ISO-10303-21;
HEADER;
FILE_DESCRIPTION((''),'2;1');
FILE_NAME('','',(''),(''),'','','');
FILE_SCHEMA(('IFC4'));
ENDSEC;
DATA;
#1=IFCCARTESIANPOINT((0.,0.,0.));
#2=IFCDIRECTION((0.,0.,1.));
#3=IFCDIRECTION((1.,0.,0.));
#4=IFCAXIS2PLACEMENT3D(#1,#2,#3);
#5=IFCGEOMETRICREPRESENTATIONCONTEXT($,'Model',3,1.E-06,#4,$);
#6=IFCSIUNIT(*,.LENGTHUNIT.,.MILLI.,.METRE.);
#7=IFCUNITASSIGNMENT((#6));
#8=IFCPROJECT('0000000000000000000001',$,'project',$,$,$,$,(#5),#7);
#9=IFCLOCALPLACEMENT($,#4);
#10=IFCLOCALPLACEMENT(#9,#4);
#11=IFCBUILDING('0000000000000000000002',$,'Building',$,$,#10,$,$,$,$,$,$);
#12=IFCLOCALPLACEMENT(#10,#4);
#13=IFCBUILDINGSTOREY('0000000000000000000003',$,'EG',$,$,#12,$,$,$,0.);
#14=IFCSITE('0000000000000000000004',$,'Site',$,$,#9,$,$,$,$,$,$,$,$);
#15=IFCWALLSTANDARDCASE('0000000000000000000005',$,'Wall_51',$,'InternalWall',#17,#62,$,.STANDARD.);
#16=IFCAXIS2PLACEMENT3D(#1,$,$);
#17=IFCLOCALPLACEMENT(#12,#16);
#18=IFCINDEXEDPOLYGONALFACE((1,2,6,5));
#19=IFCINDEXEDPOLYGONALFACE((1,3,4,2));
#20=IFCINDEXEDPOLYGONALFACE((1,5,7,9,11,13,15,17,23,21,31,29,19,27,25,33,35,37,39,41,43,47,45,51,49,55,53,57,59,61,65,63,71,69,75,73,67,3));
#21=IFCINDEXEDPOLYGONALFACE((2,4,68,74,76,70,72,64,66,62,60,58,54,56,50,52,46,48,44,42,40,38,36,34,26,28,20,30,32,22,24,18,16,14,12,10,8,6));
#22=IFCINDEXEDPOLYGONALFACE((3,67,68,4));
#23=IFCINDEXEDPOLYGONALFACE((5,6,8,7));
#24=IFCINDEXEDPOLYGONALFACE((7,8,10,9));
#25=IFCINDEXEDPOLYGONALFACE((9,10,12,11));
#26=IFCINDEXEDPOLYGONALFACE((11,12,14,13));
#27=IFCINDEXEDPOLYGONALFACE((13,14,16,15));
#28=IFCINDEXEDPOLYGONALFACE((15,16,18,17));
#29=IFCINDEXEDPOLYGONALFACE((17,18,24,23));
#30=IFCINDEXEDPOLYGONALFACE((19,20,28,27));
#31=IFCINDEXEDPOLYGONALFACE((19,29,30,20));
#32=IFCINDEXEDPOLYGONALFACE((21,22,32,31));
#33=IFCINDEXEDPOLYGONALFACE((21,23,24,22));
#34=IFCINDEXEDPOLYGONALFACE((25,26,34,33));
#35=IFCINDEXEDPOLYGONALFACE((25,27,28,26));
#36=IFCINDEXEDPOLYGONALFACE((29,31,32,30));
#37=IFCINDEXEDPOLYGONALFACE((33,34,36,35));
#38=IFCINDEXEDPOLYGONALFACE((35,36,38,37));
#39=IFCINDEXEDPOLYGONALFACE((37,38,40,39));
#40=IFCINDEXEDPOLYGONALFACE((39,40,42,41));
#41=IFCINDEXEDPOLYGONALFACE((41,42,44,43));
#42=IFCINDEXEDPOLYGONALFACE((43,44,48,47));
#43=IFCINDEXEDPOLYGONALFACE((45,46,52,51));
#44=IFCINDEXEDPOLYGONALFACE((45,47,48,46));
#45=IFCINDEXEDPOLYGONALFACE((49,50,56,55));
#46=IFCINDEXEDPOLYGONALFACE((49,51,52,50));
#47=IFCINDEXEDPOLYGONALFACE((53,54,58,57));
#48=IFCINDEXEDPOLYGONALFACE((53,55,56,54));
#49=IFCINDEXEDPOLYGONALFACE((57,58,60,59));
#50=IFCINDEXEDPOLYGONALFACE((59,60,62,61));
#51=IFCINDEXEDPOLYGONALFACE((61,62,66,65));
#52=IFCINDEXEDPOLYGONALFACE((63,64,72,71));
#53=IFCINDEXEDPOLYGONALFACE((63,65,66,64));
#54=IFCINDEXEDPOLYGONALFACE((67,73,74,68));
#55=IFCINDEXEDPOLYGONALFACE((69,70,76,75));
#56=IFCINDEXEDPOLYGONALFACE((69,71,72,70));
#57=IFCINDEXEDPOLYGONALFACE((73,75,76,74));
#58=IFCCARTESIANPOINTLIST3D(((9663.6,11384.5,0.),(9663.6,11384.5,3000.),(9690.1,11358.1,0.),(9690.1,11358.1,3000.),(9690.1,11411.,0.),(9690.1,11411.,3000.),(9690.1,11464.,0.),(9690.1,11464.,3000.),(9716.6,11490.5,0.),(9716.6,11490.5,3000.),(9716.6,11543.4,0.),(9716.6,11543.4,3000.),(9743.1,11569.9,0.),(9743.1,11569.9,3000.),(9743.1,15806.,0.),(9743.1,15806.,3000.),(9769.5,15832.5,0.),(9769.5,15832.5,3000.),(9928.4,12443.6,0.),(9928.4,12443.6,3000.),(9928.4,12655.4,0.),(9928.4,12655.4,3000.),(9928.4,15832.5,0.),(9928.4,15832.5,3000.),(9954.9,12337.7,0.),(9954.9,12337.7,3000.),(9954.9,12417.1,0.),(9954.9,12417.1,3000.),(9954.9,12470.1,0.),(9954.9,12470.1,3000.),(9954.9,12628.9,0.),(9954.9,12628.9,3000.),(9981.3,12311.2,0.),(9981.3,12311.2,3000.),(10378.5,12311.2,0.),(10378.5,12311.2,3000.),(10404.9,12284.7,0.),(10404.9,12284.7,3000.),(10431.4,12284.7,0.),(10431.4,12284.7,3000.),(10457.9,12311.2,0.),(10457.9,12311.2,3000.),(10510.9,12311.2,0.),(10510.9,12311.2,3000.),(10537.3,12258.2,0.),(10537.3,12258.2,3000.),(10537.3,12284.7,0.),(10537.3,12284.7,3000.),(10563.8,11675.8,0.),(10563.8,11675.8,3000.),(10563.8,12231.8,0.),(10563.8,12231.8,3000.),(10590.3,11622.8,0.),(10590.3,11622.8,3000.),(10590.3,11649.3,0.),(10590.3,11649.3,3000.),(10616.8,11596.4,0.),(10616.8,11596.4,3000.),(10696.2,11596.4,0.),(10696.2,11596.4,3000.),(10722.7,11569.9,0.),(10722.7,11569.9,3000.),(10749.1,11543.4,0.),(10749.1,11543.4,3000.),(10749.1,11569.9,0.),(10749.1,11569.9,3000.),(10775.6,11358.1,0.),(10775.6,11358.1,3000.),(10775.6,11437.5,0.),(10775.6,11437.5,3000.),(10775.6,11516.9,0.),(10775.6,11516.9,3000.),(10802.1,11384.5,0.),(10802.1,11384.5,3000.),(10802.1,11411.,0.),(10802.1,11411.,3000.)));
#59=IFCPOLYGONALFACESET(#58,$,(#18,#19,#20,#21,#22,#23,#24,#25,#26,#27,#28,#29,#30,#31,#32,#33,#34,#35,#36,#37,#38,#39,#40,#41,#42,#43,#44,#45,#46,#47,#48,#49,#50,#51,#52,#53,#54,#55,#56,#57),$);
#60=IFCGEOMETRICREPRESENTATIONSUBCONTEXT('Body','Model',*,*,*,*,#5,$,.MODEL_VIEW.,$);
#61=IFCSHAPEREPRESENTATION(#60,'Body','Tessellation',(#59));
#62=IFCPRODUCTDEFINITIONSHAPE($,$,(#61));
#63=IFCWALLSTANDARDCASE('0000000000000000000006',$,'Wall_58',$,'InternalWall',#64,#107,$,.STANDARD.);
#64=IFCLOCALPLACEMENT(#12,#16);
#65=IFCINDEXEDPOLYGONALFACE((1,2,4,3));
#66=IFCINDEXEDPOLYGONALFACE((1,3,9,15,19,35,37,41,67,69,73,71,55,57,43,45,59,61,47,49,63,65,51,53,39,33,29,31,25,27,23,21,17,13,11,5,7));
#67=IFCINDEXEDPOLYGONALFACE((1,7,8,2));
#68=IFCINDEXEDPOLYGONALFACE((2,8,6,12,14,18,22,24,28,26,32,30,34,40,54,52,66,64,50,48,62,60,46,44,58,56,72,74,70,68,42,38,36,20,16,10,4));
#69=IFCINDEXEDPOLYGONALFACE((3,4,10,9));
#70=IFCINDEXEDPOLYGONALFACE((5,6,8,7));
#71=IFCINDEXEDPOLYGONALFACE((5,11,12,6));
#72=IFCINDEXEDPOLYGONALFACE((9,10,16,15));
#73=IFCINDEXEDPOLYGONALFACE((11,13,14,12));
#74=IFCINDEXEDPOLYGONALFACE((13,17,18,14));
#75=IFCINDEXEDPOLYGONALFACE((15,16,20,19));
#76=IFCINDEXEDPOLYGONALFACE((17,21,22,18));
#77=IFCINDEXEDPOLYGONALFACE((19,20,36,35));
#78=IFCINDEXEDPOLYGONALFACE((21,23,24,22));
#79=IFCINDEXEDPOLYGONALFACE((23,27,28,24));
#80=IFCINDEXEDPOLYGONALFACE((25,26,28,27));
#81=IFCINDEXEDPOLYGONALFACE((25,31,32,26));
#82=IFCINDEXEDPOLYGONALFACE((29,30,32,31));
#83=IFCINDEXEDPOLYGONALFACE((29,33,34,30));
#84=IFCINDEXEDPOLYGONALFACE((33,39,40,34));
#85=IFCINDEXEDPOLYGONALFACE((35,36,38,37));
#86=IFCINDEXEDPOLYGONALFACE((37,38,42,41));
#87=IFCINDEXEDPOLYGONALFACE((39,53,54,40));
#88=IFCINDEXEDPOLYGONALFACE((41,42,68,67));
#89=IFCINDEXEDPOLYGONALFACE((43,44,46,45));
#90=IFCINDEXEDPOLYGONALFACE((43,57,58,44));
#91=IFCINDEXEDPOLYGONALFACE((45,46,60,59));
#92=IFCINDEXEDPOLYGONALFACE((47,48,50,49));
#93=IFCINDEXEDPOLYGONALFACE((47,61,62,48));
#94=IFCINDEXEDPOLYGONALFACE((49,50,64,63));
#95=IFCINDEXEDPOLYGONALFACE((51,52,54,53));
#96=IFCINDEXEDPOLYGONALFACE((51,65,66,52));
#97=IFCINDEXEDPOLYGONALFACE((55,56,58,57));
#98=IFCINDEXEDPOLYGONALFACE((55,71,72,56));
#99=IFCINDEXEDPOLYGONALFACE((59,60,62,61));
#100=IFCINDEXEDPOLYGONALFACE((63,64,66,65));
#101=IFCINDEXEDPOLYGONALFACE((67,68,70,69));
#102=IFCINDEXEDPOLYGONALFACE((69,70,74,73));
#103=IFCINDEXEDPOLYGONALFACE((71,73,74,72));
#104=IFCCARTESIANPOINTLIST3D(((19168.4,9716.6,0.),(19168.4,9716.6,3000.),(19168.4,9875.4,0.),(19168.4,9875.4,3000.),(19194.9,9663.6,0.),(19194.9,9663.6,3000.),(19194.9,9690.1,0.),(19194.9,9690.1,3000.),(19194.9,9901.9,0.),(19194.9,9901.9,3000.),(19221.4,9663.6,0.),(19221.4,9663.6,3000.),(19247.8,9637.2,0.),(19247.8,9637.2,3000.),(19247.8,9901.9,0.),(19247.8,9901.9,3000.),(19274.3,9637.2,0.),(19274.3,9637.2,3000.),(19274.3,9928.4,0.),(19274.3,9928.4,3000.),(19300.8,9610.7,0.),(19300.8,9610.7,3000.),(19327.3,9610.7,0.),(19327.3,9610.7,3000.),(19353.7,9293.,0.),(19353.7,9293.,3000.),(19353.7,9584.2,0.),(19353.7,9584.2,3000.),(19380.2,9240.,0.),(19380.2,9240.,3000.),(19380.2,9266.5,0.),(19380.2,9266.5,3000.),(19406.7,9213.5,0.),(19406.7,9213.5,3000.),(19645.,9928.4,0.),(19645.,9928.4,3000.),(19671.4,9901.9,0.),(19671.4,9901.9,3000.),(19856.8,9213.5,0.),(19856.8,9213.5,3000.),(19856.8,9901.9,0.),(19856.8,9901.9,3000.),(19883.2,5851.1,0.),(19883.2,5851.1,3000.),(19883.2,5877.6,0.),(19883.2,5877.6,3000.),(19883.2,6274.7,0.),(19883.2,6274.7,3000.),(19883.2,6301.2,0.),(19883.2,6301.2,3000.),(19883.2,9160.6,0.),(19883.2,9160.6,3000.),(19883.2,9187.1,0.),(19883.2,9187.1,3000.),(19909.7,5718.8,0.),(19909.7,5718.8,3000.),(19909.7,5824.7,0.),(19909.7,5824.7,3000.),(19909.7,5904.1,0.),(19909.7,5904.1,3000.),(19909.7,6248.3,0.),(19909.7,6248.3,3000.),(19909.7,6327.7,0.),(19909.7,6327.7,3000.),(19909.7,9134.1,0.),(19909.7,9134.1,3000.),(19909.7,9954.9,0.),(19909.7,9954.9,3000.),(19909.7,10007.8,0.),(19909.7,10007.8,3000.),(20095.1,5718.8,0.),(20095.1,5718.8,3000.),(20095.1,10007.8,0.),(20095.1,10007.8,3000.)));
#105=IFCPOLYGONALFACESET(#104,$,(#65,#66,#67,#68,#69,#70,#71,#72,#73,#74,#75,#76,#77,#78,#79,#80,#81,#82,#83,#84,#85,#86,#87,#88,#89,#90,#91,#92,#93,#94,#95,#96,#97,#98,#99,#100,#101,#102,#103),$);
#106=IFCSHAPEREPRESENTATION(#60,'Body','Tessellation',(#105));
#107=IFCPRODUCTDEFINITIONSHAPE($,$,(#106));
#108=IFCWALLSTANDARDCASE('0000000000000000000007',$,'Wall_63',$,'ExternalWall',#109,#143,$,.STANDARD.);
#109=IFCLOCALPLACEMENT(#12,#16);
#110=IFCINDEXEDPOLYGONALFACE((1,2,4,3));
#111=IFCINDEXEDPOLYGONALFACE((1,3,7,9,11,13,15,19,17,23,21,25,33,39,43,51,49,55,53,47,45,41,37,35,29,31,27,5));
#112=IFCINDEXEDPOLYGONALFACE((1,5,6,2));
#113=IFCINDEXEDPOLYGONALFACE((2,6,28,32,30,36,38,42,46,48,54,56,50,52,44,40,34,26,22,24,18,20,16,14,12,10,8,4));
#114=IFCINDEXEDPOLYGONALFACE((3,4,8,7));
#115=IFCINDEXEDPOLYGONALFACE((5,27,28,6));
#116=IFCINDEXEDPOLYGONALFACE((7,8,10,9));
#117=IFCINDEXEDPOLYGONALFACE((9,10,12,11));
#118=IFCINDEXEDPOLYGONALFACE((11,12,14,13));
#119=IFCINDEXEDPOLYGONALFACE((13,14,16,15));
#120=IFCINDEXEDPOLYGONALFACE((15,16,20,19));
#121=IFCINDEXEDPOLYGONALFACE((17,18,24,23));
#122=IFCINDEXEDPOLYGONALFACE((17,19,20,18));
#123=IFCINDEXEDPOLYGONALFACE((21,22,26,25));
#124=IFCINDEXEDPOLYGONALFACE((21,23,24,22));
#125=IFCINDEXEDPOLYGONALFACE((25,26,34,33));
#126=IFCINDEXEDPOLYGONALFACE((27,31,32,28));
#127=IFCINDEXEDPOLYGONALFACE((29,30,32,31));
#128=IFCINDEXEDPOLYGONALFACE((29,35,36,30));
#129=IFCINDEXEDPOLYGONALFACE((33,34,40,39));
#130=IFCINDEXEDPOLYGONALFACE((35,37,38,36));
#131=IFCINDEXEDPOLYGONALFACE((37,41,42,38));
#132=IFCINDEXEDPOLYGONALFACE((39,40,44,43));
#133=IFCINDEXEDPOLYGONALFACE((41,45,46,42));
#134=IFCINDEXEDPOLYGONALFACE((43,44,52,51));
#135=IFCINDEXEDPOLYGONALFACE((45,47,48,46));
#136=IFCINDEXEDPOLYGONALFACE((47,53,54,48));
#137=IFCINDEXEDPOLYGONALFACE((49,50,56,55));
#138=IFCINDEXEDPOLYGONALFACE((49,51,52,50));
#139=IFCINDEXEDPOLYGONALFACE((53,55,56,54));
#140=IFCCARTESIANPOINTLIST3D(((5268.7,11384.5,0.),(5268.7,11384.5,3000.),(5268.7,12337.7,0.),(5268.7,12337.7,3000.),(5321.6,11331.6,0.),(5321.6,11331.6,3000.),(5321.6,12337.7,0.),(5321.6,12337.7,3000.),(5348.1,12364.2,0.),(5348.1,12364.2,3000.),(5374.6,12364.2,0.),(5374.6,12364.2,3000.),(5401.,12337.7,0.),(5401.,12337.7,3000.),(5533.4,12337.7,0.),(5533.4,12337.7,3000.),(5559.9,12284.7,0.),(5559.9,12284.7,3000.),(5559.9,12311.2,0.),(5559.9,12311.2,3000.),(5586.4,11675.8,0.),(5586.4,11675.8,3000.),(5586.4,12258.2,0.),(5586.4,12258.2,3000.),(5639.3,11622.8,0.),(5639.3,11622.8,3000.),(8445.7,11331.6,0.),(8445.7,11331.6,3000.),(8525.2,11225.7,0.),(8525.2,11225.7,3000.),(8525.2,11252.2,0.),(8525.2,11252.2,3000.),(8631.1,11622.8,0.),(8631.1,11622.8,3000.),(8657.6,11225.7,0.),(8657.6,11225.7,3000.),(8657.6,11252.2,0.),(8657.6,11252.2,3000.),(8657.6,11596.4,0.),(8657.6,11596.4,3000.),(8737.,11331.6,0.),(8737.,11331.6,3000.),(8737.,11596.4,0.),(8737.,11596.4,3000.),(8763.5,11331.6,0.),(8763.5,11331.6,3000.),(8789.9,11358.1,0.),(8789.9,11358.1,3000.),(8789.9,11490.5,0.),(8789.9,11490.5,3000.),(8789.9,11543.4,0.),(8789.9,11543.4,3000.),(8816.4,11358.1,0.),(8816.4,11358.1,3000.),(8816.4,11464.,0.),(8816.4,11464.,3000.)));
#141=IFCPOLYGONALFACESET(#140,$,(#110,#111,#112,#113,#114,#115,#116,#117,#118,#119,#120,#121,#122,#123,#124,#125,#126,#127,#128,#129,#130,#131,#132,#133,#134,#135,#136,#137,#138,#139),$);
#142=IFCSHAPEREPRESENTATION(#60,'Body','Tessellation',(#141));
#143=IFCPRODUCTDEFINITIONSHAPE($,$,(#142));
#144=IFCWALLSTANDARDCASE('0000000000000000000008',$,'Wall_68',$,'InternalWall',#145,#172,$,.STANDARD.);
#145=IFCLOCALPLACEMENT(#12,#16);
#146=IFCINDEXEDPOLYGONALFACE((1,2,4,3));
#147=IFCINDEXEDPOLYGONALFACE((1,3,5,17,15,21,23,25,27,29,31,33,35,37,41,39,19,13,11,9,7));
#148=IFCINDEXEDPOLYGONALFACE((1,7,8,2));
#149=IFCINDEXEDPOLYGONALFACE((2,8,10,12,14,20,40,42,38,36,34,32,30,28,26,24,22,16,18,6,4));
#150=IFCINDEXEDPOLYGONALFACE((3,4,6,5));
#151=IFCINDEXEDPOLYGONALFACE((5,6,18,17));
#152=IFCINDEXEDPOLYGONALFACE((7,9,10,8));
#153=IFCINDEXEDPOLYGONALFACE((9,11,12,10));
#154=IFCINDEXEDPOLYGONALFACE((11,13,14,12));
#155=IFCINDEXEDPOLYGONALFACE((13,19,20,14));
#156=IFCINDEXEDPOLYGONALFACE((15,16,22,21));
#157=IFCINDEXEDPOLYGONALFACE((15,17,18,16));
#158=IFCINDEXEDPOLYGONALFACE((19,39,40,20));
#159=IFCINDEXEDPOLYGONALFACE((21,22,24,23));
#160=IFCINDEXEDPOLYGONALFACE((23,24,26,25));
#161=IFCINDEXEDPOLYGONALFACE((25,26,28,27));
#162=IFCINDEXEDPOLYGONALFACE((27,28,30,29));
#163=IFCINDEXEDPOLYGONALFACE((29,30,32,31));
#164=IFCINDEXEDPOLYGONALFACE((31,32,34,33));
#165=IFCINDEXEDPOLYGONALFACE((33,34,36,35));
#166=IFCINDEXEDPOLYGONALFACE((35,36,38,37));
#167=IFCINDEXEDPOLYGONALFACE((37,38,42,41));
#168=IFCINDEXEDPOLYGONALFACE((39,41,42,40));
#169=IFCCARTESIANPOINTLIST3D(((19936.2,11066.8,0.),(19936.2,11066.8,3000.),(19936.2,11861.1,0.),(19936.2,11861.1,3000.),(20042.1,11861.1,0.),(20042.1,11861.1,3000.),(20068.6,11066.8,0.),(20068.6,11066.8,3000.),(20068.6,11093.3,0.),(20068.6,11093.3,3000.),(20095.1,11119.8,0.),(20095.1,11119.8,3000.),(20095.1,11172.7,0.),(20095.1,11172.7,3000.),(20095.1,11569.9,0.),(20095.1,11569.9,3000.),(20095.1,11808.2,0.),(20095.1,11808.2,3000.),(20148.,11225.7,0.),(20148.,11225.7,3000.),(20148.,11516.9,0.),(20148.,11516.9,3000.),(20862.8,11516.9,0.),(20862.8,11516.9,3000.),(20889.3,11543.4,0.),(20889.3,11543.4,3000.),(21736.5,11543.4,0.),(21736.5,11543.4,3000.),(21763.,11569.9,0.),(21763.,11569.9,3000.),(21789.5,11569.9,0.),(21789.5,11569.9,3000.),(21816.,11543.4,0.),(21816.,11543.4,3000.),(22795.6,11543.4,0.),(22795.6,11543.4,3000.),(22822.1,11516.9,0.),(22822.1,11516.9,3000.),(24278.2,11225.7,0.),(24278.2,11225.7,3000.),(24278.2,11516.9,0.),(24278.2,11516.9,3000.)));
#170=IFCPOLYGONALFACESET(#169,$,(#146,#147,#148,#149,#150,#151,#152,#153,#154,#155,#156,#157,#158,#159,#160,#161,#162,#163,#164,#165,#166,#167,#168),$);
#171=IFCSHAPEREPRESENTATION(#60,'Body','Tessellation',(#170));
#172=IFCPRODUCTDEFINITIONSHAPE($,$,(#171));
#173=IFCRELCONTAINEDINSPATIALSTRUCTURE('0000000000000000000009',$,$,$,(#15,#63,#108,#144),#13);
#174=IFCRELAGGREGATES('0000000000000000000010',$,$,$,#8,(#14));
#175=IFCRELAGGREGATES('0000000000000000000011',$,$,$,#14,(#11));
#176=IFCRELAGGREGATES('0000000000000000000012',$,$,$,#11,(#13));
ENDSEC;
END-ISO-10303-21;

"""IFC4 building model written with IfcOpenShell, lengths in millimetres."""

from ifc_helpers import new_model, si_unit, frame, origin_with_axes, place, context, subcontext, project, spatial, polyline, outline, extrude, element, save


model = new_model("IFC4")

# Units and contexts
model_context = context("Model", 3, precision=1e-06, world=origin_with_axes())
body_context = subcontext(model_context, "Body", "Model", "MODEL_VIEW")
ifc_project = project(units=[si_unit("LENGTHUNIT", "METRE", prefix="MILLI")], contexts=[model_context])

# Site, building, storey
site_placement = place(None, origin_with_axes())
site = spatial("IfcSite", under=ifc_project, at=site_placement, Name="Site")
building_placement = place(site_placement, origin_with_axes())
building = spatial("IfcBuilding", under=site, at=building_placement, Name="Building")
storey_placement = place(building_placement, origin_with_axes())
storey = spatial("IfcBuildingStorey", under=building, at=storey_placement, Name="EG", Elevation=0.0)

# Walls
for number, where, z_axis, x_axis, name in (
    (1, (0.0, 0.0, 0.0), (0.0, 0.0, 1.0), (1.0, 0.0, 0.0), "Wall_51"),
):
    element("IfcWallStandardCase", number, at=place(storey_placement, frame(where, z_axis=z_axis, x_axis=x_axis)), inside=storey, Name=name, ObjectType="InternalWall", PredefinedType="STANDARD", context=body_context, shape_type="SweptSolid", body=[
        extrude(outline(polyline([(9690.1, 11358.1, 0.0), (9663.6, 11384.5, 0.0), (9690.1, 11411.0, 0.0), (9690.1, 11464.0, 0.0), (9716.6, 11490.5, 0.0), (9716.6, 11543.4, 0.0), (9743.1, 11569.9, 0.0), (9743.1, 15806.0, 0.0), (9769.5, 15832.5, 0.0), (9928.4, 15832.5, 0.0), (9928.4, 12655.4, 0.0), (9954.9, 12628.9, 0.0), (9954.9, 12470.1, 0.0), (9928.4, 12443.6, 0.0), (9954.9, 12417.1, 0.0), (9954.9, 12337.7, 0.0), (9981.3, 12311.2, 0.0), (10378.5, 12311.2, 0.0), (10404.9, 12284.7, 0.0), (10431.4, 12284.7, 0.0), (10457.9, 12311.2, 0.0), (10510.9, 12311.2, 0.0), (10537.3, 12284.7, 0.0), (10537.3, 12258.2, 0.0), (10563.8, 12231.8, 0.0), (10563.8, 11675.8, 0.0), (10590.3, 11649.3, 0.0), (10590.3, 11622.8, 0.0), (10616.8, 11596.4, 0.0), (10696.2, 11596.4, 0.0), (10722.7, 11569.9, 0.0), (10749.1, 11569.9, 0.0), (10749.1, 11543.4, 0.0), (10775.6, 11516.9, 0.0), (10775.6, 11437.5, 0.0), (10802.1, 11411.0, 0.0), (10802.1, 11384.5, 0.0), (10775.6, 11358.1, 0.0), (9690.1, 11358.1, 0.0)])), origin_with_axes(), (0.0, 0.0, 1.0), 3000.0),
    ])
for number, where, z_axis, x_axis, name in (
    (2, (0.0, 0.0, 0.0), (0.0, 0.0, 1.0), (1.0, 0.0, 0.0), "Wall_58"),
):
    element("IfcWallStandardCase", number, at=place(storey_placement, frame(where, z_axis=z_axis, x_axis=x_axis)), inside=storey, Name=name, ObjectType="InternalWall", PredefinedType="STANDARD", context=body_context, shape_type="SweptSolid", body=[
        extrude(outline(polyline([(19909.7, 5718.8, 0.0), (19909.7, 5824.7, 0.0), (19883.2, 5851.1, 0.0), (19883.2, 5877.6, 0.0), (19909.7, 5904.1, 0.0), (19909.7, 6248.3, 0.0), (19883.2, 6274.7, 0.0), (19883.2, 6301.2, 0.0), (19909.7, 6327.7, 0.0), (19909.7, 9134.1, 0.0), (19883.2, 9160.6, 0.0), (19883.2, 9187.1, 0.0), (19856.8, 9213.5, 0.0), (19406.7, 9213.5, 0.0), (19380.2, 9240.0, 0.0), (19380.2, 9266.5, 0.0), (19353.7, 9293.0, 0.0), (19353.7, 9584.2, 0.0), (19327.3, 9610.7, 0.0), (19300.8, 9610.7, 0.0), (19274.3, 9637.2, 0.0), (19247.8, 9637.2, 0.0), (19221.4, 9663.6, 0.0), (19194.9, 9663.6, 0.0), (19194.9, 9690.1, 0.0), (19168.4, 9716.6, 0.0), (19168.4, 9875.4, 0.0), (19194.9, 9901.9, 0.0), (19247.8, 9901.9, 0.0), (19274.3, 9928.4, 0.0), (19645.0, 9928.4, 0.0), (19671.4, 9901.9, 0.0), (19856.8, 9901.9, 0.0), (19909.7, 9954.9, 0.0), (19909.7, 10007.8, 0.0), (20095.1, 10007.8, 0.0), (20095.1, 5718.8, 0.0), (19909.7, 5718.8, 0.0)])), origin_with_axes(), (0.0, 0.0, 1.0), 3000.0),
    ])
for number, where, z_axis, x_axis, name in (
    (3, (0.0, 0.0, 0.0), (0.0, 0.0, 1.0), (1.0, 0.0, 0.0), "Wall_63"),
):
    element("IfcWallStandardCase", number, at=place(storey_placement, frame(where, z_axis=z_axis, x_axis=x_axis)), inside=storey, Name=name, ObjectType="ExternalWall", PredefinedType="STANDARD", context=body_context, shape_type="SweptSolid", body=[
        extrude(outline(polyline([(8525.2, 11225.7, 0.0), (8525.2, 11252.2, 0.0), (8445.7, 11331.6, 0.0), (5321.6, 11331.6, 0.0), (5268.7, 11384.5, 0.0), (5268.7, 12337.7, 0.0), (5321.6, 12337.7, 0.0), (5348.1, 12364.2, 0.0), (5374.6, 12364.2, 0.0), (5401.0, 12337.7, 0.0), (5533.4, 12337.7, 0.0), (5559.9, 12311.2, 0.0), (5559.9, 12284.7, 0.0), (5586.4, 12258.2, 0.0), (5586.4, 11675.8, 0.0), (5639.3, 11622.8, 0.0), (8631.1, 11622.8, 0.0), (8657.6, 11596.4, 0.0), (8737.0, 11596.4, 0.0), (8789.9, 11543.4, 0.0), (8789.9, 11490.5, 0.0), (8816.4, 11464.0, 0.0), (8816.4, 11358.1, 0.0), (8789.9, 11358.1, 0.0), (8763.5, 11331.6, 0.0), (8737.0, 11331.6, 0.0), (8657.6, 11252.2, 0.0), (8657.6, 11225.7, 0.0), (8525.2, 11225.7, 0.0)])), origin_with_axes(), (0.0, 0.0, 1.0), 3000.0),
    ])
for number, where, z_axis, x_axis, name in (
    (4, (0.0, 0.0, 0.0), (0.0, 0.0, 1.0), (1.0, 0.0, 0.0), "Wall_68"),
):
    element("IfcWallStandardCase", number, at=place(storey_placement, frame(where, z_axis=z_axis, x_axis=x_axis)), inside=storey, Name=name, ObjectType="InternalWall", PredefinedType="STANDARD", context=body_context, shape_type="SweptSolid", body=[
        extrude(outline(polyline([(19936.2, 11066.8, 0.0), (19936.2, 11861.1, 0.0), (20042.1, 11861.1, 0.0), (20095.1, 11808.2, 0.0), (20095.1, 11569.9, 0.0), (20148.0, 11516.9, 0.0), (20862.8, 11516.9, 0.0), (20889.3, 11543.4, 0.0), (21736.5, 11543.4, 0.0), (21763.0, 11569.9, 0.0), (21789.5, 11569.9, 0.0), (21816.0, 11543.4, 0.0), (22795.6, 11543.4, 0.0), (22822.1, 11516.9, 0.0), (24278.2, 11516.9, 0.0), (24278.2, 11225.7, 0.0), (20148.0, 11225.7, 0.0), (20095.1, 11172.7, 0.0), (20095.1, 11119.8, 0.0), (20068.6, 11093.3, 0.0), (20068.6, 11066.8, 0.0), (19936.2, 11066.8, 0.0)])), origin_with_axes(), (0.0, 0.0, 1.0), 3000.0),
    ])

save(model, "model.ifc")
